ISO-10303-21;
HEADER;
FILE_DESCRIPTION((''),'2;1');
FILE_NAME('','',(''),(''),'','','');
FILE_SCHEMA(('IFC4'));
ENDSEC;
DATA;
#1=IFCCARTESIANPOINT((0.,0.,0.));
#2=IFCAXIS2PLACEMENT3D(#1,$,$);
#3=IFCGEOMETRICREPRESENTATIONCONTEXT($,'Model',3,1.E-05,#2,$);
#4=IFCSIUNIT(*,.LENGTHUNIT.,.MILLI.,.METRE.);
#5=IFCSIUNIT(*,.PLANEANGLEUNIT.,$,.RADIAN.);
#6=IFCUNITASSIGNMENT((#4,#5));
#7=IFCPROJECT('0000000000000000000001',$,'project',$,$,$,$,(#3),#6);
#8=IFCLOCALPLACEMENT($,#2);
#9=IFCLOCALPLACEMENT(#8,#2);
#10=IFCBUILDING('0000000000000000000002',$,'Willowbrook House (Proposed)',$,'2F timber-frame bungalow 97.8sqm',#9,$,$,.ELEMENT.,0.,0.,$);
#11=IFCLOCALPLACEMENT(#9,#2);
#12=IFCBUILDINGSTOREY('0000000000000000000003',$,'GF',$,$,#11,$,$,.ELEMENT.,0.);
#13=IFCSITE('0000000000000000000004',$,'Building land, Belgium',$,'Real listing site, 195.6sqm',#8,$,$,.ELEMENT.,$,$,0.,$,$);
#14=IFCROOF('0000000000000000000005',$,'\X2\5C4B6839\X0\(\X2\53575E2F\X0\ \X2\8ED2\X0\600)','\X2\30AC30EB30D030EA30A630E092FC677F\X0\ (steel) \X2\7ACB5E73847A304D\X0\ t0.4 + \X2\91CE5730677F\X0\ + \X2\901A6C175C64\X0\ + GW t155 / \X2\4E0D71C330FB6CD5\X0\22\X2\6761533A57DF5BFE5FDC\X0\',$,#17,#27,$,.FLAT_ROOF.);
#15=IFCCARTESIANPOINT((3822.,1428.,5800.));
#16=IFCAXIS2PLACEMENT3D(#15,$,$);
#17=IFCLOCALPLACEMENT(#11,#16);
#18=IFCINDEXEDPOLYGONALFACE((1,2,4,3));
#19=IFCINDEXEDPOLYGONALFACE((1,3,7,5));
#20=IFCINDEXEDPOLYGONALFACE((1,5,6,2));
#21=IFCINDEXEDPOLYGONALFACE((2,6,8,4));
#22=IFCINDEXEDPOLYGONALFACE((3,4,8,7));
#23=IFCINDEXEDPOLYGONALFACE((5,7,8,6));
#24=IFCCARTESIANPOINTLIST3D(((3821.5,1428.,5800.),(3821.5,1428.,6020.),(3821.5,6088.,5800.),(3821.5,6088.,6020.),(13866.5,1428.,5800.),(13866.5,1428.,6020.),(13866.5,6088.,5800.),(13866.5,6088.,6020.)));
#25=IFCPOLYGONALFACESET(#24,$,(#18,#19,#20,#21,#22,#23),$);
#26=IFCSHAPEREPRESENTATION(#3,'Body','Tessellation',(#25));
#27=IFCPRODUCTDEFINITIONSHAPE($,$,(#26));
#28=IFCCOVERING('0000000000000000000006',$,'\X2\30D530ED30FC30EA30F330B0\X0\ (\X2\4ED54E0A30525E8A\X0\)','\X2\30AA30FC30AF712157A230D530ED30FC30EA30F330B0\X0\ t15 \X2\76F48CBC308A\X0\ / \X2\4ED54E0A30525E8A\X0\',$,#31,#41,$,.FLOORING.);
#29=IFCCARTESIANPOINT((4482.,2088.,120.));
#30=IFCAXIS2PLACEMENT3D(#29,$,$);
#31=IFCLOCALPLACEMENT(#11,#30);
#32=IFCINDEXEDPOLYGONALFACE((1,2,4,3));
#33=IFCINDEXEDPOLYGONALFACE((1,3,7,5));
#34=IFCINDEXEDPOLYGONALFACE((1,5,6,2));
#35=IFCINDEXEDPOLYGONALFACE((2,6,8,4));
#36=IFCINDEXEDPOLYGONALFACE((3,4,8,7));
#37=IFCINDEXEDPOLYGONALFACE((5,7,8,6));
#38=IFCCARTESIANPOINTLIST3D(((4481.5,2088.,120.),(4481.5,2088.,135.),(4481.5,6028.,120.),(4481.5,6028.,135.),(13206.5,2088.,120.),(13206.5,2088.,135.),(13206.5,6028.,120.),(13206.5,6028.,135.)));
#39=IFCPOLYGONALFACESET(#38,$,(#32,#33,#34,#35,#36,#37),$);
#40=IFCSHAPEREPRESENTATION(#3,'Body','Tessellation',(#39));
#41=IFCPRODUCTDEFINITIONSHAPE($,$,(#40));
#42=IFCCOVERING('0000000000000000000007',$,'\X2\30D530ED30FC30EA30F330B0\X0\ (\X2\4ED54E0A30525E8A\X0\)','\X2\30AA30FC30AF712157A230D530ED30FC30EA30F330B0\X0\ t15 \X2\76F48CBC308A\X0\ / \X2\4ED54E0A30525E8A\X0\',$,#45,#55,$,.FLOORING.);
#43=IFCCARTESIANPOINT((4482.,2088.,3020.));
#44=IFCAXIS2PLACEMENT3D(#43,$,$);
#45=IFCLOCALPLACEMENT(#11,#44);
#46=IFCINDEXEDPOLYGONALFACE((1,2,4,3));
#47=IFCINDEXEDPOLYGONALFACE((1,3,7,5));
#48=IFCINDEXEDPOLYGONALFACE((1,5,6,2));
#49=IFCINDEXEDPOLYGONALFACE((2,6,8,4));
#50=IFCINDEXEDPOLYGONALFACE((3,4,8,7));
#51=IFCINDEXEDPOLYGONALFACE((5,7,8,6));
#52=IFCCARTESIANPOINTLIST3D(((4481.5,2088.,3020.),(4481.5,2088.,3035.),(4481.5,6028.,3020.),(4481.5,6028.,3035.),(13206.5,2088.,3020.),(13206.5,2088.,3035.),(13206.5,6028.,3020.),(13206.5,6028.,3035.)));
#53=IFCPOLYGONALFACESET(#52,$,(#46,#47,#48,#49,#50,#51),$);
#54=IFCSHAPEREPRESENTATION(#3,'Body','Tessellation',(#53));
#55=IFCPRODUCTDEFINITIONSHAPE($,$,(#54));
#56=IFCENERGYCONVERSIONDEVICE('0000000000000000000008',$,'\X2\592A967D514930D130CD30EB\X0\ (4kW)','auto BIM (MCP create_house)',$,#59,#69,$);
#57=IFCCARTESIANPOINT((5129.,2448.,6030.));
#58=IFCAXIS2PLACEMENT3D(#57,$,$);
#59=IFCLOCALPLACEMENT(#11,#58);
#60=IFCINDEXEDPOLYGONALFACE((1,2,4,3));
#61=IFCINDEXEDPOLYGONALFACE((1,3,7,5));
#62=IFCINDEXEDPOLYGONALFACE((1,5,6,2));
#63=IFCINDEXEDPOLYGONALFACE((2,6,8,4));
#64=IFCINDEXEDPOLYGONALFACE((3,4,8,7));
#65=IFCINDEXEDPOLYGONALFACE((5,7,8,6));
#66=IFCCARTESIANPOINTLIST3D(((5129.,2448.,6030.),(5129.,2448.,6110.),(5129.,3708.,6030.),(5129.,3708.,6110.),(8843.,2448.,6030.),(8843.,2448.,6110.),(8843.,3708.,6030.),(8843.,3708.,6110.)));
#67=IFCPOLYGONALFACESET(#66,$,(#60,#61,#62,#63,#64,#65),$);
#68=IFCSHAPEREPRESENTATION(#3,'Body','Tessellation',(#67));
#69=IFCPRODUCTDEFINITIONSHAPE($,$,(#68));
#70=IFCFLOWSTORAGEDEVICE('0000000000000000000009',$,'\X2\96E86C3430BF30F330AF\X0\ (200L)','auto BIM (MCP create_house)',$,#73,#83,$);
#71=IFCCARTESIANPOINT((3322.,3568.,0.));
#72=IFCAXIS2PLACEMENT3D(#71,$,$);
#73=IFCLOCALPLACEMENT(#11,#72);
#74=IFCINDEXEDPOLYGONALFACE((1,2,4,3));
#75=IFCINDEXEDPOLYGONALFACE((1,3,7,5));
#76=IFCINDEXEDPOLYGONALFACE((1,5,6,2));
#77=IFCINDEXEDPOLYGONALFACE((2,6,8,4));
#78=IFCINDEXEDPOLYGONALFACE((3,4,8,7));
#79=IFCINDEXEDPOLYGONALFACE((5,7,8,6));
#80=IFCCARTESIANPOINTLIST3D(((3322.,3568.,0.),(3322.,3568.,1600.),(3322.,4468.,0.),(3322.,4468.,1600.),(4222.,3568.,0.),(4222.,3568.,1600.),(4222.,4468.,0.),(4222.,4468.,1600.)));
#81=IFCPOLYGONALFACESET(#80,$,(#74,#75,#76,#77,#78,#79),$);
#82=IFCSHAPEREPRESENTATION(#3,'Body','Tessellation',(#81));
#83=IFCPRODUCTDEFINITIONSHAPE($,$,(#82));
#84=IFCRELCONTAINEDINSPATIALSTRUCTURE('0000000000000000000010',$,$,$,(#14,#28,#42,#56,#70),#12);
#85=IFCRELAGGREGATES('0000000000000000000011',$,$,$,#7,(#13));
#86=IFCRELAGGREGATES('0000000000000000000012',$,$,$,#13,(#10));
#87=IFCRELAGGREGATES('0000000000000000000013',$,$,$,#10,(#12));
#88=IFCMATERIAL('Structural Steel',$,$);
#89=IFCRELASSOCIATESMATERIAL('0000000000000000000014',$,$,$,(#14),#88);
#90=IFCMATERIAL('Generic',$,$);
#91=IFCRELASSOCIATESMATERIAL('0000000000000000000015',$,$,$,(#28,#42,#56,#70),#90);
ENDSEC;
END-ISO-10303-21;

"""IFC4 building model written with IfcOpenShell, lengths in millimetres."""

from ifc_helpers import new_model, si_unit, frame, frame_2d, origin, place, context, project, spatial, rectangle, extrude, material, element, save


model = new_model("IFC4")

# Units and contexts
model_context = context("Model", 3, precision=1e-05, world=origin())
ifc_project = project(units=[si_unit("LENGTHUNIT", "METRE", prefix="MILLI"), si_unit("PLANEANGLEUNIT", "RADIAN")], contexts=[model_context])

# Site, building, storey
site_placement = place(None, origin())
site = spatial("IfcSite", under=ifc_project, at=site_placement, Name="Building land, Belgium", ObjectType="Real listing site, 195.6sqm", CompositionType="ELEMENT", RefElevation=0.0)
building_placement = place(site_placement, origin())
building = spatial("IfcBuilding", under=site, at=building_placement, Name="Willowbrook House (Proposed)", ObjectType="2F timber-frame bungalow 97.8sqm", CompositionType="ELEMENT", ElevationOfRefHeight=0.0, ElevationOfTerrain=0.0)
storey_placement = place(building_placement, origin())
storey = spatial("IfcBuildingStorey", under=building, at=storey_placement, Name="GF", CompositionType="ELEMENT", Elevation=0.0)

# Roof
ifc_material_1 = material(Name="Structural Steel")
for number, where, name in (
    (1, (3822.0, 1428.0, 5800.0), "屋根(南帯 軒600)"),
):
    element("IfcRoof", number, at=place(storey_placement, frame(where)), inside=storey, material=ifc_material_1, Name=name, Description="ガルバリウム鋼板 (steel) 立平葺き t0.4 + 野地板 + 通気層 + GW t155 / 不燃・法22条区域対応", PredefinedType="FLAT_ROOF", context=model_context, shape_type="SweptSolid", body=[
        extrude(rectangle(XDim=10045.0, YDim=4660.0, at=frame_2d((5022.0, 2330.0))), frame((3822.0, 1428.0, 5800.0)), (0.0, 0.0, 1.0), 220.0),
    ])

# Coverings
ifc_material_2 = material(Name="Generic")
covering_1_placement = place(storey_placement, frame((4482.0, 2088.0, 120.0)))
element("IfcCovering", 2, at=covering_1_placement, inside=storey, material=ifc_material_2, Name="フローリング (仕上げ床)", Description="オーク無垢フローリング t15 直貼り / 仕上げ床", PredefinedType="FLOORING", context=model_context, shape_type="SweptSolid", body=[
    extrude(rectangle(XDim=8725.0, YDim=3940.0, at=frame_2d((4362.0, 1970.0))), frame((4482.0, 2088.0, 120.0)), (0.0, 0.0, 1.0), 15.0),
])
covering_2_placement = place(storey_placement, frame((4482.0, 2088.0, 3020.0)))
element("IfcCovering", 3, at=covering_2_placement, inside=storey, material=ifc_material_2, Name="フローリング (仕上げ床)", Description="オーク無垢フローリング t15 直貼り / 仕上げ床", PredefinedType="FLOORING", context=model_context, shape_type="SweptSolid", body=[
    extrude(rectangle(XDim=8725.0, YDim=3940.0, at=frame_2d((4362.0, 1970.0))), frame((4482.0, 2088.0, 3020.0)), (0.0, 0.0, 1.0), 15.0),
])

# Energy conversion device
energy_conversion_device_placement = place(storey_placement, frame((5129.0, 2448.0, 6030.0)))
element("IfcEnergyConversionDevice", 4, at=energy_conversion_device_placement, inside=storey, material=ifc_material_2, Name="太陽光パネル (4kW)", Description="auto BIM (MCP create_house)", context=model_context, shape_type="SweptSolid", body=[
    extrude(rectangle(XDim=3714.0, YDim=1260.0, at=frame_2d((1857.0, 630.0))), frame((5129.0, 2448.0, 6030.0)), (0.0, 0.0, 1.0), 80.0),
])

# Flow storage device
flow_storage_device_placement = place(storey_placement, frame((3322.0, 3568.0, 0.0)))
element("IfcFlowStorageDevice", 5, at=flow_storage_device_placement, inside=storey, material=ifc_material_2, Name="雨水タンク (200L)", Description="auto BIM (MCP create_house)", context=model_context, shape_type="SweptSolid", body=[
    extrude(rectangle(XDim=900.0, YDim=900.0, at=frame_2d((450.0, 450.0))), frame((3322.0, 3568.0, 0.0)), (0.0, 0.0, 1.0), 1600.0),
])

save(model, "model.ifc")
